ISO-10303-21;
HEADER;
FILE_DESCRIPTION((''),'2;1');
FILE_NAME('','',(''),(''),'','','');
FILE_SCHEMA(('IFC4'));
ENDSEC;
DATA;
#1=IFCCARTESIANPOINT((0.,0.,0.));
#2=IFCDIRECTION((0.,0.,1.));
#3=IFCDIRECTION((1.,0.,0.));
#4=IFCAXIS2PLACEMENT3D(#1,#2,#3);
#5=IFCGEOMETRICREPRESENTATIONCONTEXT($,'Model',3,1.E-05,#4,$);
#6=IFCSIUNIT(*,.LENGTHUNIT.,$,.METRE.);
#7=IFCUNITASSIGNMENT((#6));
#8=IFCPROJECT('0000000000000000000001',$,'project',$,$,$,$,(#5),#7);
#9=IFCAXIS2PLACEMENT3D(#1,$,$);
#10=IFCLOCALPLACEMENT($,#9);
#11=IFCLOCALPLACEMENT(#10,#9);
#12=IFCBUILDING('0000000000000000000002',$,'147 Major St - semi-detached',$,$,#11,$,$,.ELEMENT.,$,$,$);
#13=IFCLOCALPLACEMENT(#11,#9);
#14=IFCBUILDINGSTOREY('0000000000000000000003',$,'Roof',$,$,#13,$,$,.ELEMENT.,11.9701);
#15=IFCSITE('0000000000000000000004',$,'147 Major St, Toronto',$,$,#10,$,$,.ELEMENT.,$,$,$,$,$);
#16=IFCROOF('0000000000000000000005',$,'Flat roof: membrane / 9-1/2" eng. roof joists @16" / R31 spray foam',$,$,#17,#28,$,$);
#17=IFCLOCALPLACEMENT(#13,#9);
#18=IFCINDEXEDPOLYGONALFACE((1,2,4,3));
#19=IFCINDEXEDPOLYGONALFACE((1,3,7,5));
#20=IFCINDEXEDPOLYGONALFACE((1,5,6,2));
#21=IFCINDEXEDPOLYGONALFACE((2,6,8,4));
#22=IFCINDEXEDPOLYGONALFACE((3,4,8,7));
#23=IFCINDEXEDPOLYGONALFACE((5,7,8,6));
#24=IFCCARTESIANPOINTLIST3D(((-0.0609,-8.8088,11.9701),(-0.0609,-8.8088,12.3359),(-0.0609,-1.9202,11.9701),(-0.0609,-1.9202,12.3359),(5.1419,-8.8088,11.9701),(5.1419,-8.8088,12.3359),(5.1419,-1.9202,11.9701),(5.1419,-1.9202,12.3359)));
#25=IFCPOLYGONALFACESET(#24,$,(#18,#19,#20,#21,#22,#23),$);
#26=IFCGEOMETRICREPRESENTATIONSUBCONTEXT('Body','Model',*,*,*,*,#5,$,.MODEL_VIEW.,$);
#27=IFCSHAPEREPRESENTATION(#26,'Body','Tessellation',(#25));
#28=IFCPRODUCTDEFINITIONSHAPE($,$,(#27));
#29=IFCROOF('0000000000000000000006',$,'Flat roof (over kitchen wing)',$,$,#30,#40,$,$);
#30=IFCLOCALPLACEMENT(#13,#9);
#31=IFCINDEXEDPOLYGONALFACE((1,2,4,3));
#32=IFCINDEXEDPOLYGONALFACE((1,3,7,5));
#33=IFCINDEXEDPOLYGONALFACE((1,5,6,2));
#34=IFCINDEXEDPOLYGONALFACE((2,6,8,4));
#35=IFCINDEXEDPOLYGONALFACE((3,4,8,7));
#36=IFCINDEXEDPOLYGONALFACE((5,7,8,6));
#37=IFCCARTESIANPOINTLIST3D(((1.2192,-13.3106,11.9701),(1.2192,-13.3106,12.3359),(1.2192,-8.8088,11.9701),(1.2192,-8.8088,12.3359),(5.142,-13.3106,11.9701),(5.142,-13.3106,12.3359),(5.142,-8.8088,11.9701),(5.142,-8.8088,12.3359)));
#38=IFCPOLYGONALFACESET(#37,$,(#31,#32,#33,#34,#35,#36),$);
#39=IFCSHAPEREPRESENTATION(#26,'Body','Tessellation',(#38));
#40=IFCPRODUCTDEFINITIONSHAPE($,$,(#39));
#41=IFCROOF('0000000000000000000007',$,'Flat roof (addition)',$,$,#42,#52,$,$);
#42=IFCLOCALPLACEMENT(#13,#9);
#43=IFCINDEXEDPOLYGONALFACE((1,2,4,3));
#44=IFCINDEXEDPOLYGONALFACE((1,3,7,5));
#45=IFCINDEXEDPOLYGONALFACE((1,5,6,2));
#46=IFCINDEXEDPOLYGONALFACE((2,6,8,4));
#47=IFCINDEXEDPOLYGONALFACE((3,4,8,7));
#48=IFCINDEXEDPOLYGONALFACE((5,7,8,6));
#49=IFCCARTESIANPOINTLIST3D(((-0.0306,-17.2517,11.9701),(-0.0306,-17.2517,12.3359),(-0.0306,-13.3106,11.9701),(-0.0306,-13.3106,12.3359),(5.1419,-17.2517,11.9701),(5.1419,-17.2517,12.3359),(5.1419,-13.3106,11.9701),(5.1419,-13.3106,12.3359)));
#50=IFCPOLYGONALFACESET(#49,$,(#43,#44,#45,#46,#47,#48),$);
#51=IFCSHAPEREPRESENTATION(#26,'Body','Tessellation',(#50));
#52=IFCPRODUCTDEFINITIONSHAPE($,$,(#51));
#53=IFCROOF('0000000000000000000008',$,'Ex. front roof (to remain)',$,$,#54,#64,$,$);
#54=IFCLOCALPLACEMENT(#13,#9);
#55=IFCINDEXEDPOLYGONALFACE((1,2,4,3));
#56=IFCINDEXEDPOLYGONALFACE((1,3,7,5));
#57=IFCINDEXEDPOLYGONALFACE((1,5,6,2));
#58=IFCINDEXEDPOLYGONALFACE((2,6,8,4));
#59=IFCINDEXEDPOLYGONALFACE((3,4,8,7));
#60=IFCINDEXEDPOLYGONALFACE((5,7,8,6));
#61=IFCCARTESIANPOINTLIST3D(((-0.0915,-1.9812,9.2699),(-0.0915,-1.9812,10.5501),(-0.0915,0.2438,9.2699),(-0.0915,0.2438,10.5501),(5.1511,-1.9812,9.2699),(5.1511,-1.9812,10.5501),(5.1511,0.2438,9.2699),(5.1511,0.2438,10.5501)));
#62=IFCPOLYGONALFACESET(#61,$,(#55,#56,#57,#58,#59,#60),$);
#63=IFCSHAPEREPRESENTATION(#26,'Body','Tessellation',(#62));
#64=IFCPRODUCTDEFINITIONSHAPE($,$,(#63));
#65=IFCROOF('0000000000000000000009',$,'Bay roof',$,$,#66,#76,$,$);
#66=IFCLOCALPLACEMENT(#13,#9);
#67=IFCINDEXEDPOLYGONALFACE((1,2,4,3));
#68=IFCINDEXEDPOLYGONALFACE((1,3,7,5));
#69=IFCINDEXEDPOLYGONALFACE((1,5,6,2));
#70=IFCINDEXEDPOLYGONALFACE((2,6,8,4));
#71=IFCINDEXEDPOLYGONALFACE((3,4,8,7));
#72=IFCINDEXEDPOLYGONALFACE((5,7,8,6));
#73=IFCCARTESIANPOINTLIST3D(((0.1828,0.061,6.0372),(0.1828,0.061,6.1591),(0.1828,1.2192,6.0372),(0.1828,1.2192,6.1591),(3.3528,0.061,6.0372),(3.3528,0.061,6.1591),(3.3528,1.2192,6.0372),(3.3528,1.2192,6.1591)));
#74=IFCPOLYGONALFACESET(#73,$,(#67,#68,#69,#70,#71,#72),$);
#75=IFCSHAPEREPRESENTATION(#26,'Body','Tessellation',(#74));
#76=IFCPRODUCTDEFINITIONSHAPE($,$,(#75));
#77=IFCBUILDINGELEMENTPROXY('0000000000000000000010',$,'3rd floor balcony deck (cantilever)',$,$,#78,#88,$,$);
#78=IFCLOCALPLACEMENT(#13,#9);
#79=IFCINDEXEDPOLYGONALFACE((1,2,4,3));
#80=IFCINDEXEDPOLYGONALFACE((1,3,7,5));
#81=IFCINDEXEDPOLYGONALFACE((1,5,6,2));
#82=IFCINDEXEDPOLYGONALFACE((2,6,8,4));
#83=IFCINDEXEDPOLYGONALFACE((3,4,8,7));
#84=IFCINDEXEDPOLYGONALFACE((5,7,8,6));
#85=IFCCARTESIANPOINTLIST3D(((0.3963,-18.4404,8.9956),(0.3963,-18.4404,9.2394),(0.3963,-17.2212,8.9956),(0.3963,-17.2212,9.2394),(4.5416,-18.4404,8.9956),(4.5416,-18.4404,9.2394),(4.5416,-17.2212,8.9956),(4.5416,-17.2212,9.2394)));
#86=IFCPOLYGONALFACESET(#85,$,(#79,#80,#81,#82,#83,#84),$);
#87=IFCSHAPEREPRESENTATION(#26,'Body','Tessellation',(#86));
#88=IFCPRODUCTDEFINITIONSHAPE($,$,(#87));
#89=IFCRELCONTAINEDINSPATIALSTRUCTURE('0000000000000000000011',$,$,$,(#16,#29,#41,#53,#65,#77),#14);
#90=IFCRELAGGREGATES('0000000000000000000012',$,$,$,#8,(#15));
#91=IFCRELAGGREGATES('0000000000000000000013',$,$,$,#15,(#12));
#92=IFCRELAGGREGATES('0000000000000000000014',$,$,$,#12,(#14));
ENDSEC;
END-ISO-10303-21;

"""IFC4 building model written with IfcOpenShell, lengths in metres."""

from ifc_helpers import new_model, si_unit, frame, origin, origin_with_axes, place, context, subcontext, project, spatial, rectangle, extrude, element, save


model = new_model("IFC4")

# Units and contexts
model_context = context("Model", 3, precision=1e-05, world=origin_with_axes())
body_context = subcontext(model_context, "Body", "Model", "MODEL_VIEW")
ifc_project = project(units=[si_unit("LENGTHUNIT", "METRE")], contexts=[model_context])

# Site, building, storey
site_placement = place(None, origin())
site = spatial("IfcSite", under=ifc_project, at=site_placement, Name="147 Major St, Toronto", CompositionType="ELEMENT")
building_placement = place(site_placement, origin())
building = spatial("IfcBuilding", under=site, at=building_placement, Name="147 Major St - semi-detached", CompositionType="ELEMENT")
storey_placement = place(building_placement, origin())
storey = spatial("IfcBuildingStorey", under=building, at=storey_placement, Name="Roof", CompositionType="ELEMENT", Elevation=11.9701)

# Roofs
roof_1_placement = place(storey_placement, frame((2.5405, -5.3645, 11.9701)))
element("IfcRoof", 1, at=roof_1_placement, inside=storey, Name="Flat roof: membrane / 9-1/2\" eng. roof joists @16\" / R31 spray foam", context=body_context, shape_type="SweptSolid", body=[
    extrude(rectangle(XDim=5.2029, YDim=6.8885), origin_with_axes(), (0.0, 0.0, 1.0), 0.3658),
])
roof_2_placement = place(storey_placement, frame((3.1806, -11.0597, 11.9701)))
element("IfcRoof", 2, at=roof_2_placement, inside=storey, Name="Flat roof (over kitchen wing)", context=body_context, shape_type="SweptSolid", body=[
    extrude(rectangle(XDim=3.9228, YDim=4.5019), origin_with_axes(), (0.0, 0.0, 1.0), 0.3658),
])
roof_3_placement = place(storey_placement, frame((2.5557, -15.2811, 11.9701)))
element("IfcRoof", 3, at=roof_3_placement, inside=storey, Name="Flat roof (addition)", context=body_context, shape_type="SweptSolid", body=[
    extrude(rectangle(XDim=5.1725, YDim=3.9411), origin_with_axes(), (0.0, 0.0, 1.0), 0.3658),
])
roof_4_placement = place(storey_placement, frame((2.5298, -0.8687, 9.2699)))
element("IfcRoof", 4, at=roof_4_placement, inside=storey, Name="Ex. front roof (to remain)", context=body_context, shape_type="SweptSolid", body=[
    extrude(rectangle(XDim=5.2426, YDim=2.225), origin_with_axes(), (0.0, 0.0, 1.0), 1.2802),
])
roof_5_placement = place(storey_placement, frame((1.7678, 0.6401, 6.0372)))
element("IfcRoof", 5, at=roof_5_placement, inside=storey, Name="Bay roof", context=body_context, shape_type="SweptSolid", body=[
    extrude(rectangle(XDim=3.1699, YDim=1.1582), origin_with_axes(), (0.0, 0.0, 1.0), 0.1219),
])

# Building element proxy
proxy_placement = place(storey_placement, frame((2.4689, -17.8308, 8.9956)))
element("IfcBuildingElementProxy", 6, at=proxy_placement, inside=storey, Name="3rd floor balcony deck (cantilever)", context=body_context, shape_type="SweptSolid", body=[
    extrude(rectangle(XDim=4.1453, YDim=1.2192), origin_with_axes(), (0.0, 0.0, 1.0), 0.2438),
])

save(model, "model.ifc")
